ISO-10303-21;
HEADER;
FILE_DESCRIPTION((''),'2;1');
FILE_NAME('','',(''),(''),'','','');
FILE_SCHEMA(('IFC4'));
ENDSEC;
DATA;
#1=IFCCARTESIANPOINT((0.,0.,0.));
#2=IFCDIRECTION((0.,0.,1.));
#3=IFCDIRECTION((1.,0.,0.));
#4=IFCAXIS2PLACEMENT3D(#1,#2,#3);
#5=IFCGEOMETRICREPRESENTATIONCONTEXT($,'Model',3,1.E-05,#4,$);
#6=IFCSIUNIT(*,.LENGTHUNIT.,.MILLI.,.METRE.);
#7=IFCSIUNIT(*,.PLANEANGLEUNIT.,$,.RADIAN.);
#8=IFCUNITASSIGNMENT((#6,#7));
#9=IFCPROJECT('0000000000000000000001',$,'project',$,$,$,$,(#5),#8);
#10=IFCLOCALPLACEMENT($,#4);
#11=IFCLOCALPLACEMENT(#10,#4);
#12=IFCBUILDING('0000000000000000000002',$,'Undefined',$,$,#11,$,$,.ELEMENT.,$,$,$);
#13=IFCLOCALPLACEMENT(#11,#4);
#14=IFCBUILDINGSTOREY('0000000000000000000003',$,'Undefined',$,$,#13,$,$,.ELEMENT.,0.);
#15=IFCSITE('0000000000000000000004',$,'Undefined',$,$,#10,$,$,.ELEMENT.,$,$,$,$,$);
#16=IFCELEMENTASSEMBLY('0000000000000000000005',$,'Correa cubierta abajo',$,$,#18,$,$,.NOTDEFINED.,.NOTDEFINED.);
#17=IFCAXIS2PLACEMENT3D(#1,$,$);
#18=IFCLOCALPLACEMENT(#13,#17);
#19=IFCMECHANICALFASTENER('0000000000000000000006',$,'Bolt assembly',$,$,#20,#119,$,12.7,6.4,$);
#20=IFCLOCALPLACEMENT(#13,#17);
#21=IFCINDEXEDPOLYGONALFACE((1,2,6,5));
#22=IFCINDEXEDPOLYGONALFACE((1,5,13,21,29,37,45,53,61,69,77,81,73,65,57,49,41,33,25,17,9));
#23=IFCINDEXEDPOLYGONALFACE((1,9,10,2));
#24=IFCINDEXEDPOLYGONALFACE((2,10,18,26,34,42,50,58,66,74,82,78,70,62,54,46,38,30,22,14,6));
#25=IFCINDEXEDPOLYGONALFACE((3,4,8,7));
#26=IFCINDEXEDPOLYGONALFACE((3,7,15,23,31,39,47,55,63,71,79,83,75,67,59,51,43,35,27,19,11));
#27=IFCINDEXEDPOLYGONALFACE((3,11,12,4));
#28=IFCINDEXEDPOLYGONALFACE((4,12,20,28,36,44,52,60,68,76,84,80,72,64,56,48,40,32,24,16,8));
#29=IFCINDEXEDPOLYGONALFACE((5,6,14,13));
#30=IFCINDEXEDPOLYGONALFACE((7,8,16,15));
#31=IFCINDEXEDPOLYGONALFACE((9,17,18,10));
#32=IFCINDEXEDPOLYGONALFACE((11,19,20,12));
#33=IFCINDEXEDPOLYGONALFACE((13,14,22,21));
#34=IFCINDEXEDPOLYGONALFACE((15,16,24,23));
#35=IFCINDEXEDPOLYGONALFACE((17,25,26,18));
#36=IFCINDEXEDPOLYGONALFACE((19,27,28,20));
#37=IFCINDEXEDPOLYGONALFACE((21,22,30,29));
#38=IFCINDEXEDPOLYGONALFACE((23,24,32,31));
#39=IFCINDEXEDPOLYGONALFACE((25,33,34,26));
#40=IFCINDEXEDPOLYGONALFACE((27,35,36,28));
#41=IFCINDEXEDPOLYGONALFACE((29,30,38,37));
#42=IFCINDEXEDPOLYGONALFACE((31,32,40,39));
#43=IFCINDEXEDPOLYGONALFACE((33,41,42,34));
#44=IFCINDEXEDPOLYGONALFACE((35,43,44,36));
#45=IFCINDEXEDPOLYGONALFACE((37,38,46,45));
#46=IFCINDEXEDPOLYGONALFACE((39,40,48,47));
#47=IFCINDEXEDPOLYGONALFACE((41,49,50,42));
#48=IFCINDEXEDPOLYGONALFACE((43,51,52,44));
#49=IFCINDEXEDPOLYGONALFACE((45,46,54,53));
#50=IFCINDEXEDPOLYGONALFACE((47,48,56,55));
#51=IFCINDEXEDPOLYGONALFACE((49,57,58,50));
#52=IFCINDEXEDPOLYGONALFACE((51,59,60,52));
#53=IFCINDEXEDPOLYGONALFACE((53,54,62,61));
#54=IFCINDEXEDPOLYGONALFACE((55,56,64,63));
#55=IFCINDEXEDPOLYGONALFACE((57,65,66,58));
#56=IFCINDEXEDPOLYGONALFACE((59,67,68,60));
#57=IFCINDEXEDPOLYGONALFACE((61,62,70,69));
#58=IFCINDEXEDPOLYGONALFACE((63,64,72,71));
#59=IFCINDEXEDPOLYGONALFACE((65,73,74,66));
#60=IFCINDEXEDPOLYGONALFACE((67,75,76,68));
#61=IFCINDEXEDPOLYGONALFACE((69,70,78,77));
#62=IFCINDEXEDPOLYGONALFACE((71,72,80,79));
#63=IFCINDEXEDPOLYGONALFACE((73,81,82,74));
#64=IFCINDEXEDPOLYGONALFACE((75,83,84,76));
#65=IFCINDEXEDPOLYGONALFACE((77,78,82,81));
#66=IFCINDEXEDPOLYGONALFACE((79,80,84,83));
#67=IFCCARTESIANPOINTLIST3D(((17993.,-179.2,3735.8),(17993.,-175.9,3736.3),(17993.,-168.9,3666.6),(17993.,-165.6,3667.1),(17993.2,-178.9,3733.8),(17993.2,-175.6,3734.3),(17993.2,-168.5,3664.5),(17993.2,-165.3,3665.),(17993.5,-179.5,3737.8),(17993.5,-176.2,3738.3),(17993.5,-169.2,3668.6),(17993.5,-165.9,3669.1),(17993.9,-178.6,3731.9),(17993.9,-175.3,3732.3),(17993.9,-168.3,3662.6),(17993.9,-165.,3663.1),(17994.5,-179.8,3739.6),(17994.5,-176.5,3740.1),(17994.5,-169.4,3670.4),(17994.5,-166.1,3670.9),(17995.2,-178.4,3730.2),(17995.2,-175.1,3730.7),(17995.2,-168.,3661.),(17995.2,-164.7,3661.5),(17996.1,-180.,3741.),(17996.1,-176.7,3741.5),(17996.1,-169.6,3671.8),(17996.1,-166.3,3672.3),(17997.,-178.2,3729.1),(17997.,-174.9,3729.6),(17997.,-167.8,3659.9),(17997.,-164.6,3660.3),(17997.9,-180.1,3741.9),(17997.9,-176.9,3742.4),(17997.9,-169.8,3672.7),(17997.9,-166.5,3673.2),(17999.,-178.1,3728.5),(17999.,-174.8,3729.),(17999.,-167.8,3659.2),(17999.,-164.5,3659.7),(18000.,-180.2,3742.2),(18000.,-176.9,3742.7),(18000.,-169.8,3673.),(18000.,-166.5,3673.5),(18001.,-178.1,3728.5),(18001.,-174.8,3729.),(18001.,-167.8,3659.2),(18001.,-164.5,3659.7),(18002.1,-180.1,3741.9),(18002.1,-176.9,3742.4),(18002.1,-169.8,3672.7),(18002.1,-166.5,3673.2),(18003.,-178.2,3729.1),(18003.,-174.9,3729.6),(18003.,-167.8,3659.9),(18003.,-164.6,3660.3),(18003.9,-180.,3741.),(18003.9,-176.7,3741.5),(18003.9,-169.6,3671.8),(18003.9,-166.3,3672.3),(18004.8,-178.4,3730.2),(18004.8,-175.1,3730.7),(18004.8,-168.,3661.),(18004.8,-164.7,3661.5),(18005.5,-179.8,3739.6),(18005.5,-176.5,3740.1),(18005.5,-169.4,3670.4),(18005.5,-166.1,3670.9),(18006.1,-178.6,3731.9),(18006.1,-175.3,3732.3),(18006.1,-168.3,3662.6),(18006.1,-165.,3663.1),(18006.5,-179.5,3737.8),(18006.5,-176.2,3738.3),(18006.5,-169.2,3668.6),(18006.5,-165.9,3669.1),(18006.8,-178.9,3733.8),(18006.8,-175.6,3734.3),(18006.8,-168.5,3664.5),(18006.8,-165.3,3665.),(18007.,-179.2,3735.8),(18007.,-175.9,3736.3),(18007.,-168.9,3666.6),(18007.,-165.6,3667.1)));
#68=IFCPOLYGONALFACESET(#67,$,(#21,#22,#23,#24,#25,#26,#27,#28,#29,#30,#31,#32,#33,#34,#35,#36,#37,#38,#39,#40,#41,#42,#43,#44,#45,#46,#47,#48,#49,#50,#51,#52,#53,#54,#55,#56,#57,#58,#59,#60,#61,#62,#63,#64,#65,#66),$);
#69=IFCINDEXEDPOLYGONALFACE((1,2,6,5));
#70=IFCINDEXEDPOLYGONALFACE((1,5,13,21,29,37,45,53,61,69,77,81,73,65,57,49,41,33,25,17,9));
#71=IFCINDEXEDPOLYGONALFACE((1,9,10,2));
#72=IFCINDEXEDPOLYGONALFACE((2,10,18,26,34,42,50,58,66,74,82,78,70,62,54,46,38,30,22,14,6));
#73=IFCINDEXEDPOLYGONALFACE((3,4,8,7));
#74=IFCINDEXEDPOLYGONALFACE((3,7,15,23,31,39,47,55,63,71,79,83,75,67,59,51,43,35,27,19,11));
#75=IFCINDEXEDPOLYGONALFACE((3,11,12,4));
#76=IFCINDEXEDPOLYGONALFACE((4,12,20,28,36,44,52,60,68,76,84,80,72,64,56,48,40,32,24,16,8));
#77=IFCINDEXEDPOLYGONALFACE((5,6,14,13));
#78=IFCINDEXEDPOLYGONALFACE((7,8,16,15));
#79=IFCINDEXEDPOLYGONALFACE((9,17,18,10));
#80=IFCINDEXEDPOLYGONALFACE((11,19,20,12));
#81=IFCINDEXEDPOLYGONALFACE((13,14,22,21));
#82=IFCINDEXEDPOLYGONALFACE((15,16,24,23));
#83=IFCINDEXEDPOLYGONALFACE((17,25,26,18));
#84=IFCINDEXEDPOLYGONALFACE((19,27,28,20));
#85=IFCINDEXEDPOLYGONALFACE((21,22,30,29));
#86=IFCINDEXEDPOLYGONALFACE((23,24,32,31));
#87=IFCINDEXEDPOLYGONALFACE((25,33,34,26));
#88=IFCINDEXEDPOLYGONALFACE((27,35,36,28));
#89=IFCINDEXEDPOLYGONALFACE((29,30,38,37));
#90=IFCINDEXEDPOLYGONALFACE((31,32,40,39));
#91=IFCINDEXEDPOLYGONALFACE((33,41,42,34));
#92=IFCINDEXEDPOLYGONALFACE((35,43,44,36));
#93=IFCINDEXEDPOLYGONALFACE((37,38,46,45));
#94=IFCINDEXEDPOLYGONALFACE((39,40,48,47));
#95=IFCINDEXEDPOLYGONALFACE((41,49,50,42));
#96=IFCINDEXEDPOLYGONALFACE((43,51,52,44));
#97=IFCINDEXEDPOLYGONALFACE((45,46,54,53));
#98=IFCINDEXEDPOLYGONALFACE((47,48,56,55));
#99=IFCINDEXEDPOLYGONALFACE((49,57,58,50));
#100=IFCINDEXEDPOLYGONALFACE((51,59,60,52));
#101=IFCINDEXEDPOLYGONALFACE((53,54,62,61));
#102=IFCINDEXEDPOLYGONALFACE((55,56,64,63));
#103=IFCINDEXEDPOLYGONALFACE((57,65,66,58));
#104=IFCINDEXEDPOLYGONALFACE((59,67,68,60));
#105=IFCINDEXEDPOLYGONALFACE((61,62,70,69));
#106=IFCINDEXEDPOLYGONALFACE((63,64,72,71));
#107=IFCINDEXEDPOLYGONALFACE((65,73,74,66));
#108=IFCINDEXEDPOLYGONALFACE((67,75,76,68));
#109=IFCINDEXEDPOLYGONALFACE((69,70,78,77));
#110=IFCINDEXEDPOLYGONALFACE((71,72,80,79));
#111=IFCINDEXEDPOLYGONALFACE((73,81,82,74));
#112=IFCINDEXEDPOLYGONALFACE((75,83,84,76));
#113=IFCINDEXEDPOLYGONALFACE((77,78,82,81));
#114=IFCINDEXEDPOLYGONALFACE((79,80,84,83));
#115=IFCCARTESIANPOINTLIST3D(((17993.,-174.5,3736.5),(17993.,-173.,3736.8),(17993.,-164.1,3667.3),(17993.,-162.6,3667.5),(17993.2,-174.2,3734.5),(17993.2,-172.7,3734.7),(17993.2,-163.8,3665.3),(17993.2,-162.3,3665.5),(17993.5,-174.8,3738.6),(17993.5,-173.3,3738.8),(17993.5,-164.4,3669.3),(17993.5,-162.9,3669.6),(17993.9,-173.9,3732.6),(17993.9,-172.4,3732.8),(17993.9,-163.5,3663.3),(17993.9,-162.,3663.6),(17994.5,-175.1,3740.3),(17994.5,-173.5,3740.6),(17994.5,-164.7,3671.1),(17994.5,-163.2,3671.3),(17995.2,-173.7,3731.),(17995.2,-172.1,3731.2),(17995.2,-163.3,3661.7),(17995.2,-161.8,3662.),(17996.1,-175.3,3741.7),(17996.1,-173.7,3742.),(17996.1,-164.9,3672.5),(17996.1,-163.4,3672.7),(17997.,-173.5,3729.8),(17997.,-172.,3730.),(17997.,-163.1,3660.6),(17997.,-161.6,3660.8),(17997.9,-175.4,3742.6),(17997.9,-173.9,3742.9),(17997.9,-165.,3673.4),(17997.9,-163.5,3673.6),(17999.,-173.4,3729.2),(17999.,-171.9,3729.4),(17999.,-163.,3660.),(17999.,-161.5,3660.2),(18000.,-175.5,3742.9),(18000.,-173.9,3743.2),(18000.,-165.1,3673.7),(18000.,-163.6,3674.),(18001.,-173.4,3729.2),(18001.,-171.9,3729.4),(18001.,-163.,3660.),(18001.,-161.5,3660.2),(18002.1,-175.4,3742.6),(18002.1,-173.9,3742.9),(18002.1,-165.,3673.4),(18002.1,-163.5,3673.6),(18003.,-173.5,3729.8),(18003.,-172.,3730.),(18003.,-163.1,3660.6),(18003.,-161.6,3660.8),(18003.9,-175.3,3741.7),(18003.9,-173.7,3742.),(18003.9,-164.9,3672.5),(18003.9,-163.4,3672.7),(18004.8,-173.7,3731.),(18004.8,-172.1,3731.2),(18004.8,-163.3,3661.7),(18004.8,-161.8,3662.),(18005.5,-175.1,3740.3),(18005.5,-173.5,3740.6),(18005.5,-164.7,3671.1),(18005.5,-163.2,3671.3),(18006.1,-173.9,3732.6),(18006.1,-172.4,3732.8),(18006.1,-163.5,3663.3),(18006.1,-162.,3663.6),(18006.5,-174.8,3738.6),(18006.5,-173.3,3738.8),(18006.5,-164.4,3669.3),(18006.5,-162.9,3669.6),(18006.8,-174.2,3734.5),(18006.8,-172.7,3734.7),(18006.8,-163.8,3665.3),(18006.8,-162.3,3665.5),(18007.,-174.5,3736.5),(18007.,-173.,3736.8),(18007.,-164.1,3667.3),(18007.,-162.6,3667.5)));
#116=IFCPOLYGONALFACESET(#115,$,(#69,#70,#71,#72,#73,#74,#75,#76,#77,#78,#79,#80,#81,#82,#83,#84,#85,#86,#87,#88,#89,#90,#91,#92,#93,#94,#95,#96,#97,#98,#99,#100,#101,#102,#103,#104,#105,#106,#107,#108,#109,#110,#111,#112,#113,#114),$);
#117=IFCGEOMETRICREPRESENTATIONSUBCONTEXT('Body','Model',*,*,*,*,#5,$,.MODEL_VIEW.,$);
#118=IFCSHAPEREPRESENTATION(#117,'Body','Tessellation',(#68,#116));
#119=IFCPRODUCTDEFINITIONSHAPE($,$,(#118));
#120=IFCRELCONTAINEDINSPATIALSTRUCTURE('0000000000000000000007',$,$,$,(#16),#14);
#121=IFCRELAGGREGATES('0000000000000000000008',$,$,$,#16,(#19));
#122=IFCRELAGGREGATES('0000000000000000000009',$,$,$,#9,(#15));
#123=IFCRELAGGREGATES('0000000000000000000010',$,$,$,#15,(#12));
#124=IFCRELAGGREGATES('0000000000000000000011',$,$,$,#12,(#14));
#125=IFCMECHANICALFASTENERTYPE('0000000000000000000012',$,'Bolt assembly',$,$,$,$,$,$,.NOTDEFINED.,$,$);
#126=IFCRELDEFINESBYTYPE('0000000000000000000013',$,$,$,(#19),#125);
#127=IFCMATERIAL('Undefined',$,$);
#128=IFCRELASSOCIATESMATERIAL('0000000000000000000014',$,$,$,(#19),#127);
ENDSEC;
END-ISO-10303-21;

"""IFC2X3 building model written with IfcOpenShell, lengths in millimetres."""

from ifc_helpers import new_model, si_unit, frame, origin_with_axes, origin_2d_with_axis, place, context, subcontext, project, spatial, circle, extrude, source, transform, mapped, material, type_object, element, aggregate, save


model = new_model("IFC2X3")

# Units and contexts
model_context = context("Model", 3, precision=1e-05, world=origin_with_axes())
body_context = subcontext(model_context, "Body", "Model", "MODEL_VIEW")
ifc_project = project(units=[si_unit("LENGTHUNIT", "METRE", prefix="MILLI"), si_unit("PLANEANGLEUNIT", "RADIAN")], contexts=[model_context])

# Site, building, storey
site_placement = place(None, origin_with_axes())
site = spatial("IfcSite", under=ifc_project, at=site_placement, Name="Undefined", CompositionType="ELEMENT")
building_placement = place(site_placement, origin_with_axes())
building = spatial("IfcBuilding", under=site, at=building_placement, Name="Undefined", CompositionType="ELEMENT")
storey_placement = place(building_placement, origin_with_axes())
storey = spatial("IfcBuildingStorey", under=building, at=storey_placement, Name="Undefined", CompositionType="ELEMENT", Elevation=0.0)

# Element assembly
ifc_material_1 = material(Name="Undefined")
mechanical_fastener_type = type_object("IfcMechanicalFastenerType", Name="Bolt assembly")
assembly_1_placement = place(storey_placement, origin_with_axes())
assembly_1 = element("IfcElementAssembly", 1, at=assembly_1_placement, inside=storey, Name="Correa cubierta abajo", AssemblyPlace="NOTDEFINED", PredefinedType="NOTDEFINED")

# Mechanical fastener
shared_shape_1 = source(origin_with_axes(), body_context, "Body", "SweptSolid", [
    extrude(circle(Radius=7.0, at=origin_2d_with_axis()), frame((0.0, 6.3, 0.0), z_axis=(0.0, 1.0, 0.0), x_axis=(1.0, 0.0, 0.0)), (0.0, 0.0, 1.0), 3.3),
    extrude(circle(Radius=7.0, at=origin_2d_with_axis()), frame((0.0, 3.3, 0.0), z_axis=(0.0, 1.0, 0.0), x_axis=(1.0, 0.0, 0.0)), (0.0, 0.0, 1.0), 1.6),
])
mechanical_fastener_1_placement = place(assembly_1_placement, frame((18000.0, -159.3, 3667.5), z_axis=(1.0, 0.0, 0.0), x_axis=(0.0, -0.148209, 0.988956)))
mechanical_fastener_1 = element("IfcMechanicalFastener", 2, at=mechanical_fastener_1_placement, type_object=mechanical_fastener_type, material=ifc_material_1, Name="Bolt assembly", NominalDiameter=12.7, NominalLength=6.4, context=body_context, shape_type="MappedRepresentation", body=[
    mapped(shared_shape_1, transform((0.0, 0.0, 0.0))),
    mapped(shared_shape_1, transform((70.0, 0.0, 0.0))),
])
aggregate(assembly_1, [mechanical_fastener_1])

save(model, "model.ifc")
